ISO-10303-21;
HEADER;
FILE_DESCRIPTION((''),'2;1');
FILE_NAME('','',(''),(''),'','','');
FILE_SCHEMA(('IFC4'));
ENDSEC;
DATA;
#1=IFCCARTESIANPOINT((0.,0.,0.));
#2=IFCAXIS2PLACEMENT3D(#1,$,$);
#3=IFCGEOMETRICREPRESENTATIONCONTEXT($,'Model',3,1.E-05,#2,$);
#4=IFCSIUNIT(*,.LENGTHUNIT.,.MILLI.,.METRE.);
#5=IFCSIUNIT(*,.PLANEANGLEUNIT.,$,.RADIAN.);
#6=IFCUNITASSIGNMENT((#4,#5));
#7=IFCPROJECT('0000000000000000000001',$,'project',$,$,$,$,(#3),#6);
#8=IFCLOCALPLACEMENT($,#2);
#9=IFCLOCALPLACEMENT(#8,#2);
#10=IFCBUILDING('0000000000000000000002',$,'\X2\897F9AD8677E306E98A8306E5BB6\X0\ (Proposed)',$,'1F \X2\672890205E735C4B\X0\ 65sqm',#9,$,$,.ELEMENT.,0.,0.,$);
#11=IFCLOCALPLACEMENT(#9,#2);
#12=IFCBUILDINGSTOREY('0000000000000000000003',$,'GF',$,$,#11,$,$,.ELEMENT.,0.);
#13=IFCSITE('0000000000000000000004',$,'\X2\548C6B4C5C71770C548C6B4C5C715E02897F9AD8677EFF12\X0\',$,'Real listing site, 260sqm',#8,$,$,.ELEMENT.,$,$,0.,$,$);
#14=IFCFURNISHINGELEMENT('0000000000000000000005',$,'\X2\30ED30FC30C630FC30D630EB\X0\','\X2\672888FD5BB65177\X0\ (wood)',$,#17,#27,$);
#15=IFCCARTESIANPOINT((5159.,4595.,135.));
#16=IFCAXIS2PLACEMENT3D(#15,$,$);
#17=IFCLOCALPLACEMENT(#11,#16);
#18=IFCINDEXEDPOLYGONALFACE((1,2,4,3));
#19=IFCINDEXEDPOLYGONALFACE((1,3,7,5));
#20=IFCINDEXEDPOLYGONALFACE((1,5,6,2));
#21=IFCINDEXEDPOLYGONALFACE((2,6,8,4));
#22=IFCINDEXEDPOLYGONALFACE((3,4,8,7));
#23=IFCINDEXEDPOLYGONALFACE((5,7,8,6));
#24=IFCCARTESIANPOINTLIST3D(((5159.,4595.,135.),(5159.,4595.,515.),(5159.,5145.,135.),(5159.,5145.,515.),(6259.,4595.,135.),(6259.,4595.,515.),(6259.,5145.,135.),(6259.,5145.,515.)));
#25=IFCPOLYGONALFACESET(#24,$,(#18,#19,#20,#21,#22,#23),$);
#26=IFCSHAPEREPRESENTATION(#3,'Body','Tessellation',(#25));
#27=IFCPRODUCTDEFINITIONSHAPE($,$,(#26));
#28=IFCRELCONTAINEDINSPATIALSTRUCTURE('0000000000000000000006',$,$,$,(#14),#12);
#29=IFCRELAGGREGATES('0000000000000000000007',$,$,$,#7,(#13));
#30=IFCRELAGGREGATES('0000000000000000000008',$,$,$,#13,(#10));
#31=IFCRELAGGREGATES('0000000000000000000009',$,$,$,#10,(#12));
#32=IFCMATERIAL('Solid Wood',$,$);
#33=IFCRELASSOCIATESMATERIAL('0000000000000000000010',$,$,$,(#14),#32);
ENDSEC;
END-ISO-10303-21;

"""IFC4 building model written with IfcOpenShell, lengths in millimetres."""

from ifc_helpers import new_model, si_unit, frame, frame_2d, origin, place, context, project, spatial, rectangle, extrude, material, element, save


model = new_model("IFC4")

# Units and contexts
model_context = context("Model", 3, precision=1e-05, world=origin())
ifc_project = project(units=[si_unit("LENGTHUNIT", "METRE", prefix="MILLI"), si_unit("PLANEANGLEUNIT", "RADIAN")], contexts=[model_context])

# Site, building, storey
site_placement = place(None, origin())
site = spatial("IfcSite", under=ifc_project, at=site_placement, Name="和歌山県和歌山市西高松２", ObjectType="Real listing site, 260sqm", CompositionType="ELEMENT", RefElevation=0.0)
building_placement = place(site_placement, origin())
building = spatial("IfcBuilding", under=site, at=building_placement, Name="西高松の風の家 (Proposed)", ObjectType="1F 木造平屋 65sqm", CompositionType="ELEMENT", ElevationOfRefHeight=0.0, ElevationOfTerrain=0.0)
storey_placement = place(building_placement, origin())
storey = spatial("IfcBuildingStorey", under=building, at=storey_placement, Name="GF", CompositionType="ELEMENT", Elevation=0.0)

# Shared definitions
ifc_material_1 = material(Name="Solid Wood")

# Furnishing element
furnishing_1_placement = place(storey_placement, frame((5159.0, 4595.0, 135.0)))
element("IfcFurnishingElement", 1, at=furnishing_1_placement, inside=storey, material=ifc_material_1, Name="ローテーブル", Description="木製家具 (wood)", context=model_context, shape_type="SweptSolid", body=[
    extrude(rectangle(XDim=1100.0, YDim=550.0, at=frame_2d((550.0, 275.0))), frame((5159.0, 4595.0, 135.0)), (0.0, 0.0, 1.0), 380.0),
])

save(model, "model.ifc")
